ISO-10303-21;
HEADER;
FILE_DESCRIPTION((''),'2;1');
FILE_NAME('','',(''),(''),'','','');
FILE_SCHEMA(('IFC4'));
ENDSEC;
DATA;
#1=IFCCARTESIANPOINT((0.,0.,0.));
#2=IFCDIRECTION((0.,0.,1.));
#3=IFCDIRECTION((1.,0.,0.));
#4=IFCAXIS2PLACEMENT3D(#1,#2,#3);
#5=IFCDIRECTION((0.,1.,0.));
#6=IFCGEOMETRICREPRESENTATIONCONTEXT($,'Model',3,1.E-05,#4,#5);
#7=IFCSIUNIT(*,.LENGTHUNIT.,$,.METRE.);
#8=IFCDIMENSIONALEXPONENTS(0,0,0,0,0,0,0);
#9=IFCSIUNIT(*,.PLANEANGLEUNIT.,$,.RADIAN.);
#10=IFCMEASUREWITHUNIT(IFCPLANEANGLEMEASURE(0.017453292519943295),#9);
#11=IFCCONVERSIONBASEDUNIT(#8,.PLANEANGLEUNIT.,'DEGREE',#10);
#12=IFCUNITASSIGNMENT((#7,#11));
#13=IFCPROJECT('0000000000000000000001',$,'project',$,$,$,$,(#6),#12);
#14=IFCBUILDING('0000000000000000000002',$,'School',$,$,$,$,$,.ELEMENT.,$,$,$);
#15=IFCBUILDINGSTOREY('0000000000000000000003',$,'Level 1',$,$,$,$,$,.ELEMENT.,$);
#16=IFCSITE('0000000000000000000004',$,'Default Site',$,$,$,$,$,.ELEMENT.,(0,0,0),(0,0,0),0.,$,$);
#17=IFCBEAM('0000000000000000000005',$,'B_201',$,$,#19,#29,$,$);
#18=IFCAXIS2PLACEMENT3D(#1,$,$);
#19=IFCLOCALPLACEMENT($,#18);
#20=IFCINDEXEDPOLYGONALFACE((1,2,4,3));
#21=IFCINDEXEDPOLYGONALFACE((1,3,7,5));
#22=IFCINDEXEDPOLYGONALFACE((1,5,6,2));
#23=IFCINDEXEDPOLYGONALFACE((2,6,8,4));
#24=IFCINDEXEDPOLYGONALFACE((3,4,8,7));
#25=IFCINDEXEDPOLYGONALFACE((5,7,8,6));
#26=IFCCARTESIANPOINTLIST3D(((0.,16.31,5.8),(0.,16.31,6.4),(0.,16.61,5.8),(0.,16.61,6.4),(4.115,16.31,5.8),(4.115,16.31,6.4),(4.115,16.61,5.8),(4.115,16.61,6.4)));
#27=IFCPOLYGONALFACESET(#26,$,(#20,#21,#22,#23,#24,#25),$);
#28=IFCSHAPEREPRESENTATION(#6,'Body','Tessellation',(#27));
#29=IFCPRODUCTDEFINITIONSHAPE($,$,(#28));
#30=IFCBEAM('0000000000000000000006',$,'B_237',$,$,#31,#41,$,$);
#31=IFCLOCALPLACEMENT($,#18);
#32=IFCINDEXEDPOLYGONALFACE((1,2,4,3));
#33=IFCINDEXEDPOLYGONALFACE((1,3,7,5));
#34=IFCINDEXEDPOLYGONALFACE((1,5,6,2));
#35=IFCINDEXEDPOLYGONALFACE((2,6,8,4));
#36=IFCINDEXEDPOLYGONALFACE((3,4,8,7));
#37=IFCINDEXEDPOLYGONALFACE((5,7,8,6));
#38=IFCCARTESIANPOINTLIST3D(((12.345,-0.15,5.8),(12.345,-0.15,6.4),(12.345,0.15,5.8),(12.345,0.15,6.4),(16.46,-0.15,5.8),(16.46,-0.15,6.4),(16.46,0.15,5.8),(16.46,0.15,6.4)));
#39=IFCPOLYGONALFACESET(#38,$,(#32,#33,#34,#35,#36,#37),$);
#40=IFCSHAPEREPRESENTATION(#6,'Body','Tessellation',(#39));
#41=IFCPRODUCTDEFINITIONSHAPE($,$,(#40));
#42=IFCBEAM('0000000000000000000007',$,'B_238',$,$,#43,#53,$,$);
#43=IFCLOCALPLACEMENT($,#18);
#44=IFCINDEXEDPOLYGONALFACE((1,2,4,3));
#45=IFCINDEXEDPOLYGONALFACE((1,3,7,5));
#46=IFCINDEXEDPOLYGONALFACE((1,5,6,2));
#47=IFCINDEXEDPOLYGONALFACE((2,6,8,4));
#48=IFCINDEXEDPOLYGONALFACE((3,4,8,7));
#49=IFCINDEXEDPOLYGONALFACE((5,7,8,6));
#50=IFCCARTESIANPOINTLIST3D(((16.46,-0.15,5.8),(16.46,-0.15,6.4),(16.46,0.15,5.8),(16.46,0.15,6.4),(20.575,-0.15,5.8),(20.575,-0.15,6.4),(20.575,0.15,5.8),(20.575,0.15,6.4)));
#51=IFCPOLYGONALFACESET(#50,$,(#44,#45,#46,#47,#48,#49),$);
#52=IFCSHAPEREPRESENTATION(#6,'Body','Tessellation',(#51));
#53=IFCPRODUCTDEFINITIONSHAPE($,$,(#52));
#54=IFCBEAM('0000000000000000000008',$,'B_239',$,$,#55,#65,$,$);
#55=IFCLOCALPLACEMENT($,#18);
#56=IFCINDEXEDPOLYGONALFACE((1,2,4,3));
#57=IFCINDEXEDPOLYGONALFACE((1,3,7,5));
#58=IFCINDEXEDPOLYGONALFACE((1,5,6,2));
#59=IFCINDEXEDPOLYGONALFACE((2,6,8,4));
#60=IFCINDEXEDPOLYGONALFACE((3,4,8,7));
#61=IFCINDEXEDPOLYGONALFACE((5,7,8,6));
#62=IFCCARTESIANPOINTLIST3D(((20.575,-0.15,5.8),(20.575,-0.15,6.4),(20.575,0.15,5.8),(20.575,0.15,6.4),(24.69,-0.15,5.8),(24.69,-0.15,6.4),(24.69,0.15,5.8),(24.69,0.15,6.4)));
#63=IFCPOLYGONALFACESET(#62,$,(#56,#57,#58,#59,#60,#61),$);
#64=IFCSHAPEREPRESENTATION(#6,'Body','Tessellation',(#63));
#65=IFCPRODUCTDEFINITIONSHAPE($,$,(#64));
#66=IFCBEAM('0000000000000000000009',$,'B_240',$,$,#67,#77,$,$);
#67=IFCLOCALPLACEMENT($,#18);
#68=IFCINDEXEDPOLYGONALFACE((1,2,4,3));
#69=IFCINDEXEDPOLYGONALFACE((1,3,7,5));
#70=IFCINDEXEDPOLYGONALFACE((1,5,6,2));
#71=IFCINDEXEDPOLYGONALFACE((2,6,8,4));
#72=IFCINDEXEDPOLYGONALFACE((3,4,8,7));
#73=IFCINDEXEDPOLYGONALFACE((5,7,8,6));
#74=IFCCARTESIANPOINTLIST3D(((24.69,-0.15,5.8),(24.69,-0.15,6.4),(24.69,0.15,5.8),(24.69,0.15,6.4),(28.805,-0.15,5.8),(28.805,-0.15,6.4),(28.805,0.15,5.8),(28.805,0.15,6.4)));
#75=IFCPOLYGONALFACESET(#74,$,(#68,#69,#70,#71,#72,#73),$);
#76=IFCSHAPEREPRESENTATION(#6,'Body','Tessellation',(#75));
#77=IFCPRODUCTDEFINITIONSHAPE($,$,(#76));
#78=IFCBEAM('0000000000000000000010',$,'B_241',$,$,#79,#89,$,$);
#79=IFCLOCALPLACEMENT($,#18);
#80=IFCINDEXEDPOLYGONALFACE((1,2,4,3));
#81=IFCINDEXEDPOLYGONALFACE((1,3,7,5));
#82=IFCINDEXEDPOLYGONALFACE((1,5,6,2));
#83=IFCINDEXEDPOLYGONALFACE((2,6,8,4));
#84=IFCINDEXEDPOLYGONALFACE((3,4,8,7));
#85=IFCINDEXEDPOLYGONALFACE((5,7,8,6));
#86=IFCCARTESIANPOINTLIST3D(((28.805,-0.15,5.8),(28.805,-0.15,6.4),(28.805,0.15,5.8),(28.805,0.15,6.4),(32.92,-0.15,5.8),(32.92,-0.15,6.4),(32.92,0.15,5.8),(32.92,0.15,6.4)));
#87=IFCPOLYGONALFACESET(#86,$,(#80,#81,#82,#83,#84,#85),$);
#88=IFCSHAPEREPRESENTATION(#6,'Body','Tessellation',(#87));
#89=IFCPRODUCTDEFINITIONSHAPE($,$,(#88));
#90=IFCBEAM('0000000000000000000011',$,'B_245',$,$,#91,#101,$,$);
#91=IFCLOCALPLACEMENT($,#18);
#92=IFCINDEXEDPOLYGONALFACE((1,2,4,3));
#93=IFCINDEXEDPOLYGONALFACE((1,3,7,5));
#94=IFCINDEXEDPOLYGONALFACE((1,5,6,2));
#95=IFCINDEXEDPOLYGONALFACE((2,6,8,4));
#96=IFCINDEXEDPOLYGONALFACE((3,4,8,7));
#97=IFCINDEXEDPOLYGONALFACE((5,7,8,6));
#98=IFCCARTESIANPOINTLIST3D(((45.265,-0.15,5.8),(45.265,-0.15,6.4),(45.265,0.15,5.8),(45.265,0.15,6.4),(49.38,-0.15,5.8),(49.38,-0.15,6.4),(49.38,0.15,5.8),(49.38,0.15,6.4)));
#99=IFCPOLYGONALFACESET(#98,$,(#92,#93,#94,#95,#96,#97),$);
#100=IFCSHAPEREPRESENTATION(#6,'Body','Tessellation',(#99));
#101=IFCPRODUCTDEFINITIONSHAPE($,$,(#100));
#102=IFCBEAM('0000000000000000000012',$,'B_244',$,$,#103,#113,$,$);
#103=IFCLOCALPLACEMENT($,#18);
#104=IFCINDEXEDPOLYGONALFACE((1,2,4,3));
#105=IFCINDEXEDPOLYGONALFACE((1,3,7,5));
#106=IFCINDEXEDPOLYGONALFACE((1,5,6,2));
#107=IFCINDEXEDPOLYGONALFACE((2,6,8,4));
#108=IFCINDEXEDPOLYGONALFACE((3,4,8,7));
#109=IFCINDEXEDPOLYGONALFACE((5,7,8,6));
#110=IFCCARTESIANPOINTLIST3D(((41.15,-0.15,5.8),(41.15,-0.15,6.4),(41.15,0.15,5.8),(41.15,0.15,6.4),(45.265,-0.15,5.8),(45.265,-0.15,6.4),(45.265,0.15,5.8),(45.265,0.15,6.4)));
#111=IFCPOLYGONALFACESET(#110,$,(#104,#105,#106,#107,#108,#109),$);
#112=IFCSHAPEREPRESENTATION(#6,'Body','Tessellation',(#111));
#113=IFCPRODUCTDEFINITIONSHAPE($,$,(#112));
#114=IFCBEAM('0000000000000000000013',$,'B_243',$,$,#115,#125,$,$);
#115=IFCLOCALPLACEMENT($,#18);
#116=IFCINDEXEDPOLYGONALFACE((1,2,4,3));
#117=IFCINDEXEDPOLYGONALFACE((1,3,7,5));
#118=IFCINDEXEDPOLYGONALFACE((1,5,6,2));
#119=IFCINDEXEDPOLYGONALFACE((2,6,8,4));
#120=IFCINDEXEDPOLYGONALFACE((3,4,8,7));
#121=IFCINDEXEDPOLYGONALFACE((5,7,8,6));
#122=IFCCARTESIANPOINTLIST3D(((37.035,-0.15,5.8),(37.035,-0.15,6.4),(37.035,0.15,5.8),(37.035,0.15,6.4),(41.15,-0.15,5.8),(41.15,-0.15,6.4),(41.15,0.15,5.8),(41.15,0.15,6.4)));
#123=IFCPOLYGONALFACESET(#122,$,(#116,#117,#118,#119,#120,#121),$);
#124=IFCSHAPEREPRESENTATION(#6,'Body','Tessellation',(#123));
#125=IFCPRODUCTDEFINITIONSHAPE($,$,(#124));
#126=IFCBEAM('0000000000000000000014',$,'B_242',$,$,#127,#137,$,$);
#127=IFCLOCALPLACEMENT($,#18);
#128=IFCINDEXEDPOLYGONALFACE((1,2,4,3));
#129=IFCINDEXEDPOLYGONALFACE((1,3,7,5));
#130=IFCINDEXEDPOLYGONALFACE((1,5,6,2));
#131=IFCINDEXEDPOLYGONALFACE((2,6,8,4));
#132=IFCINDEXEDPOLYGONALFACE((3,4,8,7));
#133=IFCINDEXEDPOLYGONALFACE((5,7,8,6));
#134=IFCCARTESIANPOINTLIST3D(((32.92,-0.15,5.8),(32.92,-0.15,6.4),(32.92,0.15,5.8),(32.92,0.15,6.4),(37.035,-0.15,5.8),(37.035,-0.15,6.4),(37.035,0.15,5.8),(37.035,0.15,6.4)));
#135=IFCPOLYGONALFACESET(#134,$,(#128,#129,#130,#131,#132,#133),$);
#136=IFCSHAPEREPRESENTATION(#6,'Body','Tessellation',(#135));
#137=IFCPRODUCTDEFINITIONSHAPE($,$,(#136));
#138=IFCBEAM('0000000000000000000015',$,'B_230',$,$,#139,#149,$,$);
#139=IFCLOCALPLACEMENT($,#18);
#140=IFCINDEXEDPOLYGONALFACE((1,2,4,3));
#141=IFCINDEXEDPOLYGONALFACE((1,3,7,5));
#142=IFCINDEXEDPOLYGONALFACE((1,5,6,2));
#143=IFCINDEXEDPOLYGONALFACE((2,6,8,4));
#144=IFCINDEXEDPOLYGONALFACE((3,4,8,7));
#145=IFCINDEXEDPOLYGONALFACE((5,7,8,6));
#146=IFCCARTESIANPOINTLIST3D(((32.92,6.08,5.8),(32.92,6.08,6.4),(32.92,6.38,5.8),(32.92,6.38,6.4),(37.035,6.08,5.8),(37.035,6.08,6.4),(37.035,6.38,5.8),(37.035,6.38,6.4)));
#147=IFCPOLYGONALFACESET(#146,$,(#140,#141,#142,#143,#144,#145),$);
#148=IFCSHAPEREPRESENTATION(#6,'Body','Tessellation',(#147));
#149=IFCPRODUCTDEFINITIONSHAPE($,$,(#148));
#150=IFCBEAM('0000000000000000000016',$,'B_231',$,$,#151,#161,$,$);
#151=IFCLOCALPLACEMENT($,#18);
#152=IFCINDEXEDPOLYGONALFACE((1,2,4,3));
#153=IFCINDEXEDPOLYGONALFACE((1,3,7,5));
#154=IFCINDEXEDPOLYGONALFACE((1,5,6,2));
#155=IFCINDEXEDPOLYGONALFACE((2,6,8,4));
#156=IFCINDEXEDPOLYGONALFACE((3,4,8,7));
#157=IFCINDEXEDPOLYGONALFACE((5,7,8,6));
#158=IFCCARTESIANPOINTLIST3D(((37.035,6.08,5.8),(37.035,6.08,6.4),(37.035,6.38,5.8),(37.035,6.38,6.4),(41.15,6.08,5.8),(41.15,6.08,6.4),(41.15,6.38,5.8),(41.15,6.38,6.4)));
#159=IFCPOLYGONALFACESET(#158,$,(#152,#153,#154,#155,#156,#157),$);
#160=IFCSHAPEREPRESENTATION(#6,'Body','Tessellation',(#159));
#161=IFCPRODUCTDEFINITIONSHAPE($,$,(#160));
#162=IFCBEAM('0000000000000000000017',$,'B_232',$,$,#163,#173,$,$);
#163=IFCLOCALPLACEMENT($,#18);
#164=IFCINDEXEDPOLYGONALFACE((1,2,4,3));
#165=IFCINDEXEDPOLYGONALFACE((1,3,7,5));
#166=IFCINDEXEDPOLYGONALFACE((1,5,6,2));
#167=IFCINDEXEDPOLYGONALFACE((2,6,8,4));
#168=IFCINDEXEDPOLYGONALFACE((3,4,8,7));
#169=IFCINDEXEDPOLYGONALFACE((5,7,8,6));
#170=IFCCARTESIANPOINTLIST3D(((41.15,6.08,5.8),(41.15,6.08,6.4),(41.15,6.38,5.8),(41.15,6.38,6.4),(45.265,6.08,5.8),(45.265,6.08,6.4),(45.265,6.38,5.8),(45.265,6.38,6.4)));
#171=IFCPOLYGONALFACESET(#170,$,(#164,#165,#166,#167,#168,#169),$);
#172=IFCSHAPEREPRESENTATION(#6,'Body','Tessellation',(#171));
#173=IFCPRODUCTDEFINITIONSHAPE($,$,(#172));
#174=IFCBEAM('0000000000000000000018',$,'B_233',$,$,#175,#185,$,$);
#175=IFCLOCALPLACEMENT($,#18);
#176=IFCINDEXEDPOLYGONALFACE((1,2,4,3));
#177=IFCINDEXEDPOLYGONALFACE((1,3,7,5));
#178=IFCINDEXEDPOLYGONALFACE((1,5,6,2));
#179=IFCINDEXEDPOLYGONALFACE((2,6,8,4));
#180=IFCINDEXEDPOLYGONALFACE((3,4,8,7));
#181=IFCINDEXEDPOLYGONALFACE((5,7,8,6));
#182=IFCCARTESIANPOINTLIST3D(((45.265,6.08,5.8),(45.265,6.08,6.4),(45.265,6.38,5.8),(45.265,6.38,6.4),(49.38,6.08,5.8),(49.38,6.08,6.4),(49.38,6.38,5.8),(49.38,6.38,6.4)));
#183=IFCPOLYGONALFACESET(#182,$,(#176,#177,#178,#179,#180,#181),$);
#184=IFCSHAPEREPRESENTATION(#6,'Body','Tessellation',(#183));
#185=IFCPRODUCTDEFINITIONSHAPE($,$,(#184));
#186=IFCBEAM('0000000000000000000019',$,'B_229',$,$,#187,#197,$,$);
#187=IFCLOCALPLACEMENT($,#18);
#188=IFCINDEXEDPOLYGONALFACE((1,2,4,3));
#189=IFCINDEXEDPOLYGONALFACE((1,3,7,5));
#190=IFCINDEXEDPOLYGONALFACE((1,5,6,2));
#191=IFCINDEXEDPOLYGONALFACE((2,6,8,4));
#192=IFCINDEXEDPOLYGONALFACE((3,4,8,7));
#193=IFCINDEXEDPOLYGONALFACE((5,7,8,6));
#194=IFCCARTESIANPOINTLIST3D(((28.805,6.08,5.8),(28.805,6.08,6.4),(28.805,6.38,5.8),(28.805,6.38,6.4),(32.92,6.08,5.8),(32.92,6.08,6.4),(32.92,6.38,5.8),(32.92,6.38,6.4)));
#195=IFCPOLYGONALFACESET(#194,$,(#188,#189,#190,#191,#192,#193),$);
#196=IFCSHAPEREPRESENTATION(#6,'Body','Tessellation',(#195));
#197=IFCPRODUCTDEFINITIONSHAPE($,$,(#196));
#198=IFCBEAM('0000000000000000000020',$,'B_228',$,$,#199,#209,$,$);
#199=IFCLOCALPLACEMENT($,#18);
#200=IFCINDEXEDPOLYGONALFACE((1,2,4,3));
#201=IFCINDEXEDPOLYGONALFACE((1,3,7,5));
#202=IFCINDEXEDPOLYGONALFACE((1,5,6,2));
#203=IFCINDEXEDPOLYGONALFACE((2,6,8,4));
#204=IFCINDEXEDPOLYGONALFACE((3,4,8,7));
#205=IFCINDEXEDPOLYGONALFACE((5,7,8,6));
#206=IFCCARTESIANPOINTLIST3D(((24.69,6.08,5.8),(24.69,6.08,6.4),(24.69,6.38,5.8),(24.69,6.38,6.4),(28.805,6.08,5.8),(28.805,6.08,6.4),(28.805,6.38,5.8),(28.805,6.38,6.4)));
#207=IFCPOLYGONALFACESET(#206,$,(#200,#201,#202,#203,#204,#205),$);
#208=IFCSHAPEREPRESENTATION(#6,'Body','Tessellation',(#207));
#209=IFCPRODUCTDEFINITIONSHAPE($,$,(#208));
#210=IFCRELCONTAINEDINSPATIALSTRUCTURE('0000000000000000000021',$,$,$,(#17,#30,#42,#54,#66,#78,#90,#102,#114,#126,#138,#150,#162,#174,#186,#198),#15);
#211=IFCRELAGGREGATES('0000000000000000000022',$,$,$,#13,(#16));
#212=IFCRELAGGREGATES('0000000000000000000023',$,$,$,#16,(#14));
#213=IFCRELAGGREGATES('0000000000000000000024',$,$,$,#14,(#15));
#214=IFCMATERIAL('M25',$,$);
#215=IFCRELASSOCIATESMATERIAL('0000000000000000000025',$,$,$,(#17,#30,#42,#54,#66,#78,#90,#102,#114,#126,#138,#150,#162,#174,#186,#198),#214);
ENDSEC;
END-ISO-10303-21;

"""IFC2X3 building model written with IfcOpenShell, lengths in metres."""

from ifc_helpers import new_model, entity, si_unit, converted_unit, direction, frame, frame_2d, origin_with_axes, place, context, project, spatial, rectangle, extrude, material, element, save


model = new_model("IFC2X3")

# Units and contexts
model_context = context("Model", 3, precision=1e-05, world=origin_with_axes(), true_north=direction((0.0, 1.0, 0.0)))
ifc_project = project(units=[si_unit("LENGTHUNIT", "METRE"), converted_unit("PLANEANGLEUNIT", "DEGREE", entity("IfcPlaneAngleMeasure", 0.017453292519943295), si_unit("PLANEANGLEUNIT", "RADIAN"), dimensions=[0, 0, 0, 0, 0, 0, 0])], contexts=[model_context])

# Site, building, storey
site = spatial("IfcSite", under=ifc_project, Name="Default Site", CompositionType="ELEMENT", RefLatitude=(0, 0, 0), RefLongitude=(0, 0, 0), RefElevation=0.0)
building = spatial("IfcBuilding", under=site, Name="School", CompositionType="ELEMENT")
storey = spatial("IfcBuildingStorey", under=building, Name="Level 1", CompositionType="ELEMENT")

# Shared definitions
ifc_material = material(Name="M25")
placement = place(None, origin_with_axes())

# Beams
element("IfcBeam", 1, at=placement, inside=storey, material=ifc_material, Name="B_201", context=model_context, shape_type="SweptSolid", body=[
    extrude(rectangle(XDim=0.3, YDim=0.6, at=frame_2d((0.0, 0.0), x_axis=(0.0, 1.0, 0.0))), frame((0.0, 16.46, 6.1), z_axis=(1.0, 0.0, 0.0), x_axis=(0.0, 0.0, -1.0)), (0.0, 0.0, 1.0), 4.115),
])
element("IfcBeam", 2, at=placement, inside=storey, material=ifc_material, Name="B_237", context=model_context, shape_type="SweptSolid", body=[
    extrude(rectangle(XDim=0.3, YDim=0.6, at=frame_2d((0.0, 0.0), x_axis=(0.0, 1.0, 0.0))), frame((12.345, 0.0, 6.1), z_axis=(1.0, 0.0, 0.0), x_axis=(0.0, 0.0, -1.0)), (0.0, 0.0, 1.0), 4.115),
])
element("IfcBeam", 3, at=placement, inside=storey, material=ifc_material, Name="B_238", context=model_context, shape_type="SweptSolid", body=[
    extrude(rectangle(XDim=0.3, YDim=0.6, at=frame_2d((0.0, 0.0), x_axis=(0.0, 1.0, 0.0))), frame((16.46, 0.0, 6.1), z_axis=(1.0, 0.0, 0.0), x_axis=(0.0, 0.0, -1.0)), (0.0, 0.0, 1.0), 4.115),
])
element("IfcBeam", 4, at=placement, inside=storey, material=ifc_material, Name="B_239", context=model_context, shape_type="SweptSolid", body=[
    extrude(rectangle(XDim=0.3, YDim=0.6, at=frame_2d((0.0, 0.0), x_axis=(0.0, 1.0, 0.0))), frame((20.575, 0.0, 6.1), z_axis=(1.0, 0.0, 0.0), x_axis=(0.0, 0.0, -1.0)), (0.0, 0.0, 1.0), 4.115),
])
element("IfcBeam", 5, at=placement, inside=storey, material=ifc_material, Name="B_240", context=model_context, shape_type="SweptSolid", body=[
    extrude(rectangle(XDim=0.3, YDim=0.6, at=frame_2d((0.0, 0.0), x_axis=(0.0, 1.0, 0.0))), frame((24.69, 0.0, 6.1), z_axis=(1.0, 0.0, 0.0), x_axis=(0.0, 0.0, -1.0)), (0.0, 0.0, 1.0), 4.115),
])
element("IfcBeam", 6, at=placement, inside=storey, material=ifc_material, Name="B_241", context=model_context, shape_type="SweptSolid", body=[
    extrude(rectangle(XDim=0.3, YDim=0.6, at=frame_2d((0.0, 0.0), x_axis=(0.0, 1.0, 0.0))), frame((28.805, 0.0, 6.1), z_axis=(1.0, 0.0, 0.0), x_axis=(0.0, 0.0, -1.0)), (0.0, 0.0, 1.0), 4.115),
])
element("IfcBeam", 7, at=placement, inside=storey, material=ifc_material, Name="B_245", context=model_context, shape_type="SweptSolid", body=[
    extrude(rectangle(XDim=0.3, YDim=0.6, at=frame_2d((0.0, 0.0), x_axis=(0.0, 1.0, 0.0))), frame((45.265, 0.0, 6.1), z_axis=(1.0, 0.0, 0.0), x_axis=(0.0, 0.0, -1.0)), (0.0, 0.0, 1.0), 4.115),
])
element("IfcBeam", 8, at=placement, inside=storey, material=ifc_material, Name="B_244", context=model_context, shape_type="SweptSolid", body=[
    extrude(rectangle(XDim=0.3, YDim=0.6, at=frame_2d((0.0, 0.0), x_axis=(0.0, 1.0, 0.0))), frame((41.15, 0.0, 6.1), z_axis=(1.0, 0.0, 0.0), x_axis=(0.0, 0.0, -1.0)), (0.0, 0.0, 1.0), 4.115),
])
element("IfcBeam", 9, at=placement, inside=storey, material=ifc_material, Name="B_243", context=model_context, shape_type="SweptSolid", body=[
    extrude(rectangle(XDim=0.3, YDim=0.6, at=frame_2d((0.0, 0.0), x_axis=(0.0, 1.0, 0.0))), frame((37.035, 0.0, 6.1), z_axis=(1.0, 0.0, 0.0), x_axis=(0.0, 0.0, -1.0)), (0.0, 0.0, 1.0), 4.115),
])
element("IfcBeam", 10, at=placement, inside=storey, material=ifc_material, Name="B_242", context=model_context, shape_type="SweptSolid", body=[
    extrude(rectangle(XDim=0.3, YDim=0.6, at=frame_2d((0.0, 0.0), x_axis=(0.0, 1.0, 0.0))), frame((32.92, 0.0, 6.1), z_axis=(1.0, 0.0, 0.0), x_axis=(0.0, 0.0, -1.0)), (0.0, 0.0, 1.0), 4.115),
])
element("IfcBeam", 11, at=placement, inside=storey, material=ifc_material, Name="B_230", context=model_context, shape_type="SweptSolid", body=[
    extrude(rectangle(XDim=0.3, YDim=0.6, at=frame_2d((0.0, 0.0), x_axis=(0.0, 1.0, 0.0))), frame((32.92, 6.23, 6.1), z_axis=(1.0, 0.0, 0.0), x_axis=(0.0, 0.0, -1.0)), (0.0, 0.0, 1.0), 4.115),
])
element("IfcBeam", 12, at=placement, inside=storey, material=ifc_material, Name="B_231", context=model_context, shape_type="SweptSolid", body=[
    extrude(rectangle(XDim=0.3, YDim=0.6, at=frame_2d((0.0, 0.0), x_axis=(0.0, 1.0, 0.0))), frame((37.035, 6.23, 6.1), z_axis=(1.0, 0.0, 0.0), x_axis=(0.0, 0.0, -1.0)), (0.0, 0.0, 1.0), 4.115),
])
element("IfcBeam", 13, at=placement, inside=storey, material=ifc_material, Name="B_232", context=model_context, shape_type="SweptSolid", body=[
    extrude(rectangle(XDim=0.3, YDim=0.6, at=frame_2d((0.0, 0.0), x_axis=(0.0, 1.0, 0.0))), frame((41.15, 6.23, 6.1), z_axis=(1.0, 0.0, 0.0), x_axis=(0.0, 0.0, -1.0)), (0.0, 0.0, 1.0), 4.115),
])
element("IfcBeam", 14, at=placement, inside=storey, material=ifc_material, Name="B_233", context=model_context, shape_type="SweptSolid", body=[
    extrude(rectangle(XDim=0.3, YDim=0.6, at=frame_2d((0.0, 0.0), x_axis=(0.0, 1.0, 0.0))), frame((45.265, 6.23, 6.1), z_axis=(1.0, 0.0, 0.0), x_axis=(0.0, 0.0, -1.0)), (0.0, 0.0, 1.0), 4.115),
])
element("IfcBeam", 15, at=placement, inside=storey, material=ifc_material, Name="B_229", context=model_context, shape_type="SweptSolid", body=[
    extrude(rectangle(XDim=0.3, YDim=0.6, at=frame_2d((0.0, 0.0), x_axis=(0.0, 1.0, 0.0))), frame((28.805, 6.23, 6.1), z_axis=(1.0, 0.0, 0.0), x_axis=(0.0, 0.0, -1.0)), (0.0, 0.0, 1.0), 4.115),
])
element("IfcBeam", 16, at=placement, inside=storey, material=ifc_material, Name="B_228", context=model_context, shape_type="SweptSolid", body=[
    extrude(rectangle(XDim=0.3, YDim=0.6, at=frame_2d((0.0, 0.0), x_axis=(0.0, 1.0, 0.0))), frame((24.69, 6.23, 6.1), z_axis=(1.0, 0.0, 0.0), x_axis=(0.0, 0.0, -1.0)), (0.0, 0.0, 1.0), 4.115),
])

save(model, "model.ifc")
